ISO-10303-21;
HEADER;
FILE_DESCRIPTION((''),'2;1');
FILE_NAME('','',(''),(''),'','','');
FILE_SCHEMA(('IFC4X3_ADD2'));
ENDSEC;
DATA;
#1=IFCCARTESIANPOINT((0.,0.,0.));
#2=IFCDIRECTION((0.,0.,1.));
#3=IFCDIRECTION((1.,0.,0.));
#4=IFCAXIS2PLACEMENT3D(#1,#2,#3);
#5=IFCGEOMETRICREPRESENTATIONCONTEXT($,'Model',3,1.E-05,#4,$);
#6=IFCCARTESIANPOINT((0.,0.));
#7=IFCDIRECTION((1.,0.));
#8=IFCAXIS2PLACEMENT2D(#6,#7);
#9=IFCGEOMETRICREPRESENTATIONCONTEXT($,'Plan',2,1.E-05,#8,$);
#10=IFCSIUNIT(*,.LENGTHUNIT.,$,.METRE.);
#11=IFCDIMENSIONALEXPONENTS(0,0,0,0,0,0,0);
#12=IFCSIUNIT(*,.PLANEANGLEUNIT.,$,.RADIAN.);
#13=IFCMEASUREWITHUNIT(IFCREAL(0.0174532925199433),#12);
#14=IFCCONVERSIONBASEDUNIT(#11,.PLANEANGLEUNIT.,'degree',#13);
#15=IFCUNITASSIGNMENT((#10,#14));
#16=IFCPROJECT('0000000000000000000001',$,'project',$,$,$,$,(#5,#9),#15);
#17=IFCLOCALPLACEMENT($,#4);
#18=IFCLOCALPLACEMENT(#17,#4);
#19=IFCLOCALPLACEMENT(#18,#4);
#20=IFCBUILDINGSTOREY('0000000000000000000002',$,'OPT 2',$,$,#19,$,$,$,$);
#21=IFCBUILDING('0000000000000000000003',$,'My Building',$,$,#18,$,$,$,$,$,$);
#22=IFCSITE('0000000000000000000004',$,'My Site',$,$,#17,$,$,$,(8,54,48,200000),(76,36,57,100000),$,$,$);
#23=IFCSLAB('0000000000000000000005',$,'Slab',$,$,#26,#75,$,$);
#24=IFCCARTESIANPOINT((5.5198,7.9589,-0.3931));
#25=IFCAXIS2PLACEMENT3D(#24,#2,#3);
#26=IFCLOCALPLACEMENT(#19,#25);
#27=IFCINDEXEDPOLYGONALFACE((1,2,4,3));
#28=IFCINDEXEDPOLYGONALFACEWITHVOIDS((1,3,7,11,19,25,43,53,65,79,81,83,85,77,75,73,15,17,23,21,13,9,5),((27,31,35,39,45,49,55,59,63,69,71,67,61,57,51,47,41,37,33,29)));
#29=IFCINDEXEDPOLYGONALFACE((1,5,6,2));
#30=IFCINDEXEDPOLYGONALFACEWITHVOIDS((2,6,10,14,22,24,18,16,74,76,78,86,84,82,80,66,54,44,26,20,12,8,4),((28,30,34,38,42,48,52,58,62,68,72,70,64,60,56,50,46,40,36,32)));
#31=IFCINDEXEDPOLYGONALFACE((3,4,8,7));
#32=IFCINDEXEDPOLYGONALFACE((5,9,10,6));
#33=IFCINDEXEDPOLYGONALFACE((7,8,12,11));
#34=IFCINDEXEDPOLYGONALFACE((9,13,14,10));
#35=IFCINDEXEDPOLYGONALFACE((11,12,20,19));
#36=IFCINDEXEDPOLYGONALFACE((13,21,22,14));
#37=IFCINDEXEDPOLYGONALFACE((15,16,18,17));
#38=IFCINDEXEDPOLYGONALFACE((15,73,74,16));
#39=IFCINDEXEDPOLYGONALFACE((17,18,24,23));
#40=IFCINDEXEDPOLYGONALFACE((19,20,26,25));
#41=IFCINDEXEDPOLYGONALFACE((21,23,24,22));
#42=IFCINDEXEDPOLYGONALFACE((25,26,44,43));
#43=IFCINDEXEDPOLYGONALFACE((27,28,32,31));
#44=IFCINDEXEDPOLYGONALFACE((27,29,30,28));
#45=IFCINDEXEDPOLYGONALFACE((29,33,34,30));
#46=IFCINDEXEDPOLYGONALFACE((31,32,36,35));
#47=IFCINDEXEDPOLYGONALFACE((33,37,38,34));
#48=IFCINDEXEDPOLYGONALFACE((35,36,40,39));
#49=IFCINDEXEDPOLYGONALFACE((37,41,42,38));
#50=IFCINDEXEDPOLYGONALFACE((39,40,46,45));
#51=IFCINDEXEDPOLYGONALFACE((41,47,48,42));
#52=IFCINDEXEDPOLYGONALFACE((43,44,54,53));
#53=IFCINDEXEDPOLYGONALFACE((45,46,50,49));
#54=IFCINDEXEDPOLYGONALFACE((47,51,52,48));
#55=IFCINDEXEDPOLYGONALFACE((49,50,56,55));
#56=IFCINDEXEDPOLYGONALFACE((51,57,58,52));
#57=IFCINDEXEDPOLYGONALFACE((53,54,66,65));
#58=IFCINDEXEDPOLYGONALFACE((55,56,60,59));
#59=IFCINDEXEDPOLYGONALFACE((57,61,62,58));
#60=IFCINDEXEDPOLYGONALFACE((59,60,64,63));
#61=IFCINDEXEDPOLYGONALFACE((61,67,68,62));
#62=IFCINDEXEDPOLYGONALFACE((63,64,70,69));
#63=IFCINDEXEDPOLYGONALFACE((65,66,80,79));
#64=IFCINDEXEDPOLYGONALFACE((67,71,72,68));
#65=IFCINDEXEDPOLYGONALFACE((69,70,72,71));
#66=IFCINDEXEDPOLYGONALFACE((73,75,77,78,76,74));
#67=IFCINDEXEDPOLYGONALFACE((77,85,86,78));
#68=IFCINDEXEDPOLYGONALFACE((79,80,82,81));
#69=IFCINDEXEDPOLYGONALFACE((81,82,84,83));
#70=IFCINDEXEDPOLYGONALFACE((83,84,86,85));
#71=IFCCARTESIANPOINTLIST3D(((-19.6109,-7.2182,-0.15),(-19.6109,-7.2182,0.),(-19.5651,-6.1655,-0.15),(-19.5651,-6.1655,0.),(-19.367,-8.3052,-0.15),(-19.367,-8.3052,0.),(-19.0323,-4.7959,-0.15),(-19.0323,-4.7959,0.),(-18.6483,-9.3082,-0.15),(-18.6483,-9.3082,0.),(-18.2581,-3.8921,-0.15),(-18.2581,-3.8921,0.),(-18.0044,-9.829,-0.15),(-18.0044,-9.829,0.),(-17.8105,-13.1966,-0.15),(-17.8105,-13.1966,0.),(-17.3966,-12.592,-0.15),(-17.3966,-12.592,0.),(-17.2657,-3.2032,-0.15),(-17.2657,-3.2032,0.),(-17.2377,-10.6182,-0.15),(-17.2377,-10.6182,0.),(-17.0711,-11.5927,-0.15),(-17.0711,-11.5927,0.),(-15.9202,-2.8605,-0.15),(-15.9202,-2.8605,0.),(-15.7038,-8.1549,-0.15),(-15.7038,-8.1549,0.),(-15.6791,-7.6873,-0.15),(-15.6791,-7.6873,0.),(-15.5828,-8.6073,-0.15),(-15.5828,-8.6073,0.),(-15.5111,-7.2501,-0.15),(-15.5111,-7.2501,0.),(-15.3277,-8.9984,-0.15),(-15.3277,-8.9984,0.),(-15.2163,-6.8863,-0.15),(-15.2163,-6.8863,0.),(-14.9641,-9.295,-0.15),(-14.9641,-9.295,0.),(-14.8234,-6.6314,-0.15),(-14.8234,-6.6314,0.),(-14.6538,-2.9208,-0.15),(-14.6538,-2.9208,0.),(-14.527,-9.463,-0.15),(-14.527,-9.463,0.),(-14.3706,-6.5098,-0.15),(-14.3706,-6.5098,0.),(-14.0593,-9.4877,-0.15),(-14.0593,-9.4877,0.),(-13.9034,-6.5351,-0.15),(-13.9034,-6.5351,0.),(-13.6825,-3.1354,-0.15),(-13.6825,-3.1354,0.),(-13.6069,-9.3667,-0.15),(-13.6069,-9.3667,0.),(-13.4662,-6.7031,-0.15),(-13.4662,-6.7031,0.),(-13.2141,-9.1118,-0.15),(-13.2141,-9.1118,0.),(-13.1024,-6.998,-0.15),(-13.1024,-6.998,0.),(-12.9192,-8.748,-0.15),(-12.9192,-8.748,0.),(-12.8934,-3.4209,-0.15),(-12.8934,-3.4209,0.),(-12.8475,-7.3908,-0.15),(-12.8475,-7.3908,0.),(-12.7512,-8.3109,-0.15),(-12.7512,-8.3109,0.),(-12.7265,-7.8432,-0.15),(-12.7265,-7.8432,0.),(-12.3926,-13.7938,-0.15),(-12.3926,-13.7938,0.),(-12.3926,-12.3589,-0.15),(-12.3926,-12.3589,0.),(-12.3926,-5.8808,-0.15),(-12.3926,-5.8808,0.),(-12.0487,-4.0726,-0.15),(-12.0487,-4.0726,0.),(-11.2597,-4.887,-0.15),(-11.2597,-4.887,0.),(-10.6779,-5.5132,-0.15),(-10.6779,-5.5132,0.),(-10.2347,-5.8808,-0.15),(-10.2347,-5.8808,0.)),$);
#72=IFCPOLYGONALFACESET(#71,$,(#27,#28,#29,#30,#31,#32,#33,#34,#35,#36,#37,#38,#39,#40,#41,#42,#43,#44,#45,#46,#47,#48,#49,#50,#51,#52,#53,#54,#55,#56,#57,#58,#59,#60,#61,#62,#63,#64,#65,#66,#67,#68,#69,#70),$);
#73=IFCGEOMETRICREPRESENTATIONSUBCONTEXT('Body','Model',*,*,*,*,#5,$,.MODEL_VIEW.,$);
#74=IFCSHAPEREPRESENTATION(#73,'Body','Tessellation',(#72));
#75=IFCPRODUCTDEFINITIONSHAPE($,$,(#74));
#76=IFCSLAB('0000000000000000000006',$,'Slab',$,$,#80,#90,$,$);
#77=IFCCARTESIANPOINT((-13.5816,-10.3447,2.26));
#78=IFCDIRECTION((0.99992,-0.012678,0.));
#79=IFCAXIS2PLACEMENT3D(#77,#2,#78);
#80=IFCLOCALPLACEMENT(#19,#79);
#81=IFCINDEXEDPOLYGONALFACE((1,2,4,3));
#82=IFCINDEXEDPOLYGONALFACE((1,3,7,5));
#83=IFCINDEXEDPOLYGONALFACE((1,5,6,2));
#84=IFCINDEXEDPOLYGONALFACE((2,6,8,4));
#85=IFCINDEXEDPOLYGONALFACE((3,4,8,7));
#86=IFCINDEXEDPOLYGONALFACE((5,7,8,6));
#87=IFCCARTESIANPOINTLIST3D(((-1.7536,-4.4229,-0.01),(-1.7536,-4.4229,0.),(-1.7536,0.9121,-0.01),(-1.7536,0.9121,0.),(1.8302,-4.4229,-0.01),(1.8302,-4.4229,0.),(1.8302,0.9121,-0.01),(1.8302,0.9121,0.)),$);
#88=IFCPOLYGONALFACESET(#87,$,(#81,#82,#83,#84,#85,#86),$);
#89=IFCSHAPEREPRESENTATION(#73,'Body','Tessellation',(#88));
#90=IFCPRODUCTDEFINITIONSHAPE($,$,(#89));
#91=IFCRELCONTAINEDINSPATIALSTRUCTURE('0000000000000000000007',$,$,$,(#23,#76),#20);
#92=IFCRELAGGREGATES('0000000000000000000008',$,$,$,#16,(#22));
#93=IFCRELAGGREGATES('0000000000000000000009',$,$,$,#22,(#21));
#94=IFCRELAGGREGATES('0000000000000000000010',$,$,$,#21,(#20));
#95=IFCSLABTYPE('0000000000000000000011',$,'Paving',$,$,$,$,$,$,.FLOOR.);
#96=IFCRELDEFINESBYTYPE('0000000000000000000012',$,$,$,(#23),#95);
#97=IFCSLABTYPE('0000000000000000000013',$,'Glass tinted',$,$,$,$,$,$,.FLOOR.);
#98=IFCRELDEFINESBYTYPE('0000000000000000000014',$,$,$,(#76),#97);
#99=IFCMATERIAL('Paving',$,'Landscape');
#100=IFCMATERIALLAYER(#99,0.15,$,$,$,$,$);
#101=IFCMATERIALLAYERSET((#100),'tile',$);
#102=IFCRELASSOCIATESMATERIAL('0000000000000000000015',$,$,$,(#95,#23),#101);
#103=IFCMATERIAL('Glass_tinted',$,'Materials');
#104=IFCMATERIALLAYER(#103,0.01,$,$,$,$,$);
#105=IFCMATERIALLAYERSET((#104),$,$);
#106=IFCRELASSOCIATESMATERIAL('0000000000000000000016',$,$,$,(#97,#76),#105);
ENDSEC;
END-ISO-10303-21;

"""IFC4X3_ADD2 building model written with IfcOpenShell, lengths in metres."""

from ifc_helpers import new_model, entity, si_unit, converted_unit, frame, origin_with_axes, origin_2d_with_axis, place, context, subcontext, project, spatial, indexed_curve, outline, extrude, material, layer, layer_set, layer_usage, type_object, element, save


model = new_model("IFC4X3_ADD2")

# Units and contexts
model_context = context("Model", 3, precision=1e-05, world=origin_with_axes())
plan_context = context("Plan", 2, precision=1e-05, world=origin_2d_with_axis())
body_context = subcontext(model_context, "Body", "Model", "MODEL_VIEW")
ifc_project = project(units=[si_unit("LENGTHUNIT", "METRE"), converted_unit("PLANEANGLEUNIT", "degree", entity("IfcReal", 0.0174532925199433), si_unit("PLANEANGLEUNIT", "RADIAN"), dimensions=[0, 0, 0, 0, 0, 0, 0])], contexts=[model_context, plan_context])

# Site, building, storey
site_placement = place(None, origin_with_axes())
site = spatial("IfcSite", under=ifc_project, at=site_placement, Name="My Site", RefLatitude=(8, 54, 48, 200000), RefLongitude=(76, 36, 57, 100000))
building_placement = place(site_placement, origin_with_axes())
building = spatial("IfcBuilding", under=site, at=building_placement, Name="My Building")
storey_placement = place(building_placement, origin_with_axes())
storey = spatial("IfcBuildingStorey", under=building, at=storey_placement, Name="OPT 2")

# Slabs
ifc_material_1 = material(Name="Paving", Category="Landscape")
ifc_layer_1 = layer(ifc_material_1, 0.15)
ifc_layer_set_1 = layer_set([ifc_layer_1], Name="tile")
ifc_layer_usage_1 = layer_usage(ifc_layer_set_1, "AXIS3", "POSITIVE", -0.15)
slab_type_1 = type_object("IfcSlabType", Name="Paving", PredefinedType="FLOOR", material=ifc_layer_set_1)
slab_1_placement = place(storey_placement, frame((5.5198, 7.9589, -0.3931), z_axis=(0.0, 0.0, 1.0), x_axis=(1.0, 0.0, 0.0)))
element("IfcSlab", 1, at=slab_1_placement, inside=storey, type_object=slab_type_1, material=ifc_layer_usage_1, Name="Slab", context=body_context, shape_type="SweptSolid", body=[
    extrude(outline(indexed_curve([(-17.3966, -12.592), (-17.8105, -13.1966), (-12.3926, -13.7938), (-12.3926, -12.3589), (-12.3926, -5.8808), (-10.2347, -5.8808), (-10.6779, -5.5132), (-11.2597, -4.887), (-12.0487, -4.0726), (-12.8934, -3.4209), (-13.6825, -3.1354), (-14.6538, -2.9208), (-15.9202, -2.8605), (-17.2657, -3.2032), (-18.2581, -3.8921), (-19.0323, -4.7959), (-19.5651, -6.1655), (-19.6109, -7.2182), (-19.367, -8.3052), (-18.6483, -9.3082), (-18.0044, -9.829), (-17.2377, -10.6182), (-17.0711, -11.5927), (-17.3966, -12.592)]), holes=[indexed_curve([(-14.9641, -9.295), (-14.527, -9.463), (-14.0593, -9.4877), (-13.6069, -9.3667), (-13.2141, -9.1118), (-12.9192, -8.748), (-12.7512, -8.3109), (-12.7265, -7.8432), (-12.8475, -7.3908), (-13.1024, -6.998), (-13.4662, -6.7031), (-13.9034, -6.5351), (-14.3706, -6.5098), (-14.8234, -6.6314), (-15.2163, -6.8863), (-15.5111, -7.2501), (-15.6791, -7.6873), (-15.7038, -8.1549), (-15.5828, -8.6073), (-15.3277, -8.9984), (-14.9641, -9.295)])]), frame((0.0, 0.0, -0.15), z_axis=(0.0, 0.0, 1.0), x_axis=(1.0, 0.0, 0.0)), (0.0, 0.0, 1.0), 0.15),
])
ifc_material_2 = material(Name="Glass_tinted", Category="Materials")
ifc_layer_2 = layer(ifc_material_2, 0.01)
ifc_layer_set_2 = layer_set([ifc_layer_2])
ifc_layer_usage_2 = layer_usage(ifc_layer_set_2, "AXIS3", "POSITIVE", -0.01)
slab_type_2 = type_object("IfcSlabType", Name="Glass tinted", PredefinedType="FLOOR", material=ifc_layer_set_2)
slab_2_placement = place(storey_placement, frame((-13.5816, -10.3447, 2.26), z_axis=(0.0, 0.0, 1.0), x_axis=(0.99992, -0.012678, 0.0)))
element("IfcSlab", 2, at=slab_2_placement, inside=storey, type_object=slab_type_2, material=ifc_layer_usage_2, Name="Slab", context=body_context, shape_type="SweptSolid", body=[
    extrude(outline(indexed_curve([(-1.7536, -4.4229), (1.8302, -4.4229), (1.8302, 0.9121), (-1.7536, 0.9121), (-1.7536, -4.4229)])), frame((0.0, 0.0, -0.01), z_axis=(0.0, 0.0, 1.0), x_axis=(1.0, 0.0, 0.0)), (0.0, 0.0, 1.0), 0.01),
])

save(model, "model.ifc")
